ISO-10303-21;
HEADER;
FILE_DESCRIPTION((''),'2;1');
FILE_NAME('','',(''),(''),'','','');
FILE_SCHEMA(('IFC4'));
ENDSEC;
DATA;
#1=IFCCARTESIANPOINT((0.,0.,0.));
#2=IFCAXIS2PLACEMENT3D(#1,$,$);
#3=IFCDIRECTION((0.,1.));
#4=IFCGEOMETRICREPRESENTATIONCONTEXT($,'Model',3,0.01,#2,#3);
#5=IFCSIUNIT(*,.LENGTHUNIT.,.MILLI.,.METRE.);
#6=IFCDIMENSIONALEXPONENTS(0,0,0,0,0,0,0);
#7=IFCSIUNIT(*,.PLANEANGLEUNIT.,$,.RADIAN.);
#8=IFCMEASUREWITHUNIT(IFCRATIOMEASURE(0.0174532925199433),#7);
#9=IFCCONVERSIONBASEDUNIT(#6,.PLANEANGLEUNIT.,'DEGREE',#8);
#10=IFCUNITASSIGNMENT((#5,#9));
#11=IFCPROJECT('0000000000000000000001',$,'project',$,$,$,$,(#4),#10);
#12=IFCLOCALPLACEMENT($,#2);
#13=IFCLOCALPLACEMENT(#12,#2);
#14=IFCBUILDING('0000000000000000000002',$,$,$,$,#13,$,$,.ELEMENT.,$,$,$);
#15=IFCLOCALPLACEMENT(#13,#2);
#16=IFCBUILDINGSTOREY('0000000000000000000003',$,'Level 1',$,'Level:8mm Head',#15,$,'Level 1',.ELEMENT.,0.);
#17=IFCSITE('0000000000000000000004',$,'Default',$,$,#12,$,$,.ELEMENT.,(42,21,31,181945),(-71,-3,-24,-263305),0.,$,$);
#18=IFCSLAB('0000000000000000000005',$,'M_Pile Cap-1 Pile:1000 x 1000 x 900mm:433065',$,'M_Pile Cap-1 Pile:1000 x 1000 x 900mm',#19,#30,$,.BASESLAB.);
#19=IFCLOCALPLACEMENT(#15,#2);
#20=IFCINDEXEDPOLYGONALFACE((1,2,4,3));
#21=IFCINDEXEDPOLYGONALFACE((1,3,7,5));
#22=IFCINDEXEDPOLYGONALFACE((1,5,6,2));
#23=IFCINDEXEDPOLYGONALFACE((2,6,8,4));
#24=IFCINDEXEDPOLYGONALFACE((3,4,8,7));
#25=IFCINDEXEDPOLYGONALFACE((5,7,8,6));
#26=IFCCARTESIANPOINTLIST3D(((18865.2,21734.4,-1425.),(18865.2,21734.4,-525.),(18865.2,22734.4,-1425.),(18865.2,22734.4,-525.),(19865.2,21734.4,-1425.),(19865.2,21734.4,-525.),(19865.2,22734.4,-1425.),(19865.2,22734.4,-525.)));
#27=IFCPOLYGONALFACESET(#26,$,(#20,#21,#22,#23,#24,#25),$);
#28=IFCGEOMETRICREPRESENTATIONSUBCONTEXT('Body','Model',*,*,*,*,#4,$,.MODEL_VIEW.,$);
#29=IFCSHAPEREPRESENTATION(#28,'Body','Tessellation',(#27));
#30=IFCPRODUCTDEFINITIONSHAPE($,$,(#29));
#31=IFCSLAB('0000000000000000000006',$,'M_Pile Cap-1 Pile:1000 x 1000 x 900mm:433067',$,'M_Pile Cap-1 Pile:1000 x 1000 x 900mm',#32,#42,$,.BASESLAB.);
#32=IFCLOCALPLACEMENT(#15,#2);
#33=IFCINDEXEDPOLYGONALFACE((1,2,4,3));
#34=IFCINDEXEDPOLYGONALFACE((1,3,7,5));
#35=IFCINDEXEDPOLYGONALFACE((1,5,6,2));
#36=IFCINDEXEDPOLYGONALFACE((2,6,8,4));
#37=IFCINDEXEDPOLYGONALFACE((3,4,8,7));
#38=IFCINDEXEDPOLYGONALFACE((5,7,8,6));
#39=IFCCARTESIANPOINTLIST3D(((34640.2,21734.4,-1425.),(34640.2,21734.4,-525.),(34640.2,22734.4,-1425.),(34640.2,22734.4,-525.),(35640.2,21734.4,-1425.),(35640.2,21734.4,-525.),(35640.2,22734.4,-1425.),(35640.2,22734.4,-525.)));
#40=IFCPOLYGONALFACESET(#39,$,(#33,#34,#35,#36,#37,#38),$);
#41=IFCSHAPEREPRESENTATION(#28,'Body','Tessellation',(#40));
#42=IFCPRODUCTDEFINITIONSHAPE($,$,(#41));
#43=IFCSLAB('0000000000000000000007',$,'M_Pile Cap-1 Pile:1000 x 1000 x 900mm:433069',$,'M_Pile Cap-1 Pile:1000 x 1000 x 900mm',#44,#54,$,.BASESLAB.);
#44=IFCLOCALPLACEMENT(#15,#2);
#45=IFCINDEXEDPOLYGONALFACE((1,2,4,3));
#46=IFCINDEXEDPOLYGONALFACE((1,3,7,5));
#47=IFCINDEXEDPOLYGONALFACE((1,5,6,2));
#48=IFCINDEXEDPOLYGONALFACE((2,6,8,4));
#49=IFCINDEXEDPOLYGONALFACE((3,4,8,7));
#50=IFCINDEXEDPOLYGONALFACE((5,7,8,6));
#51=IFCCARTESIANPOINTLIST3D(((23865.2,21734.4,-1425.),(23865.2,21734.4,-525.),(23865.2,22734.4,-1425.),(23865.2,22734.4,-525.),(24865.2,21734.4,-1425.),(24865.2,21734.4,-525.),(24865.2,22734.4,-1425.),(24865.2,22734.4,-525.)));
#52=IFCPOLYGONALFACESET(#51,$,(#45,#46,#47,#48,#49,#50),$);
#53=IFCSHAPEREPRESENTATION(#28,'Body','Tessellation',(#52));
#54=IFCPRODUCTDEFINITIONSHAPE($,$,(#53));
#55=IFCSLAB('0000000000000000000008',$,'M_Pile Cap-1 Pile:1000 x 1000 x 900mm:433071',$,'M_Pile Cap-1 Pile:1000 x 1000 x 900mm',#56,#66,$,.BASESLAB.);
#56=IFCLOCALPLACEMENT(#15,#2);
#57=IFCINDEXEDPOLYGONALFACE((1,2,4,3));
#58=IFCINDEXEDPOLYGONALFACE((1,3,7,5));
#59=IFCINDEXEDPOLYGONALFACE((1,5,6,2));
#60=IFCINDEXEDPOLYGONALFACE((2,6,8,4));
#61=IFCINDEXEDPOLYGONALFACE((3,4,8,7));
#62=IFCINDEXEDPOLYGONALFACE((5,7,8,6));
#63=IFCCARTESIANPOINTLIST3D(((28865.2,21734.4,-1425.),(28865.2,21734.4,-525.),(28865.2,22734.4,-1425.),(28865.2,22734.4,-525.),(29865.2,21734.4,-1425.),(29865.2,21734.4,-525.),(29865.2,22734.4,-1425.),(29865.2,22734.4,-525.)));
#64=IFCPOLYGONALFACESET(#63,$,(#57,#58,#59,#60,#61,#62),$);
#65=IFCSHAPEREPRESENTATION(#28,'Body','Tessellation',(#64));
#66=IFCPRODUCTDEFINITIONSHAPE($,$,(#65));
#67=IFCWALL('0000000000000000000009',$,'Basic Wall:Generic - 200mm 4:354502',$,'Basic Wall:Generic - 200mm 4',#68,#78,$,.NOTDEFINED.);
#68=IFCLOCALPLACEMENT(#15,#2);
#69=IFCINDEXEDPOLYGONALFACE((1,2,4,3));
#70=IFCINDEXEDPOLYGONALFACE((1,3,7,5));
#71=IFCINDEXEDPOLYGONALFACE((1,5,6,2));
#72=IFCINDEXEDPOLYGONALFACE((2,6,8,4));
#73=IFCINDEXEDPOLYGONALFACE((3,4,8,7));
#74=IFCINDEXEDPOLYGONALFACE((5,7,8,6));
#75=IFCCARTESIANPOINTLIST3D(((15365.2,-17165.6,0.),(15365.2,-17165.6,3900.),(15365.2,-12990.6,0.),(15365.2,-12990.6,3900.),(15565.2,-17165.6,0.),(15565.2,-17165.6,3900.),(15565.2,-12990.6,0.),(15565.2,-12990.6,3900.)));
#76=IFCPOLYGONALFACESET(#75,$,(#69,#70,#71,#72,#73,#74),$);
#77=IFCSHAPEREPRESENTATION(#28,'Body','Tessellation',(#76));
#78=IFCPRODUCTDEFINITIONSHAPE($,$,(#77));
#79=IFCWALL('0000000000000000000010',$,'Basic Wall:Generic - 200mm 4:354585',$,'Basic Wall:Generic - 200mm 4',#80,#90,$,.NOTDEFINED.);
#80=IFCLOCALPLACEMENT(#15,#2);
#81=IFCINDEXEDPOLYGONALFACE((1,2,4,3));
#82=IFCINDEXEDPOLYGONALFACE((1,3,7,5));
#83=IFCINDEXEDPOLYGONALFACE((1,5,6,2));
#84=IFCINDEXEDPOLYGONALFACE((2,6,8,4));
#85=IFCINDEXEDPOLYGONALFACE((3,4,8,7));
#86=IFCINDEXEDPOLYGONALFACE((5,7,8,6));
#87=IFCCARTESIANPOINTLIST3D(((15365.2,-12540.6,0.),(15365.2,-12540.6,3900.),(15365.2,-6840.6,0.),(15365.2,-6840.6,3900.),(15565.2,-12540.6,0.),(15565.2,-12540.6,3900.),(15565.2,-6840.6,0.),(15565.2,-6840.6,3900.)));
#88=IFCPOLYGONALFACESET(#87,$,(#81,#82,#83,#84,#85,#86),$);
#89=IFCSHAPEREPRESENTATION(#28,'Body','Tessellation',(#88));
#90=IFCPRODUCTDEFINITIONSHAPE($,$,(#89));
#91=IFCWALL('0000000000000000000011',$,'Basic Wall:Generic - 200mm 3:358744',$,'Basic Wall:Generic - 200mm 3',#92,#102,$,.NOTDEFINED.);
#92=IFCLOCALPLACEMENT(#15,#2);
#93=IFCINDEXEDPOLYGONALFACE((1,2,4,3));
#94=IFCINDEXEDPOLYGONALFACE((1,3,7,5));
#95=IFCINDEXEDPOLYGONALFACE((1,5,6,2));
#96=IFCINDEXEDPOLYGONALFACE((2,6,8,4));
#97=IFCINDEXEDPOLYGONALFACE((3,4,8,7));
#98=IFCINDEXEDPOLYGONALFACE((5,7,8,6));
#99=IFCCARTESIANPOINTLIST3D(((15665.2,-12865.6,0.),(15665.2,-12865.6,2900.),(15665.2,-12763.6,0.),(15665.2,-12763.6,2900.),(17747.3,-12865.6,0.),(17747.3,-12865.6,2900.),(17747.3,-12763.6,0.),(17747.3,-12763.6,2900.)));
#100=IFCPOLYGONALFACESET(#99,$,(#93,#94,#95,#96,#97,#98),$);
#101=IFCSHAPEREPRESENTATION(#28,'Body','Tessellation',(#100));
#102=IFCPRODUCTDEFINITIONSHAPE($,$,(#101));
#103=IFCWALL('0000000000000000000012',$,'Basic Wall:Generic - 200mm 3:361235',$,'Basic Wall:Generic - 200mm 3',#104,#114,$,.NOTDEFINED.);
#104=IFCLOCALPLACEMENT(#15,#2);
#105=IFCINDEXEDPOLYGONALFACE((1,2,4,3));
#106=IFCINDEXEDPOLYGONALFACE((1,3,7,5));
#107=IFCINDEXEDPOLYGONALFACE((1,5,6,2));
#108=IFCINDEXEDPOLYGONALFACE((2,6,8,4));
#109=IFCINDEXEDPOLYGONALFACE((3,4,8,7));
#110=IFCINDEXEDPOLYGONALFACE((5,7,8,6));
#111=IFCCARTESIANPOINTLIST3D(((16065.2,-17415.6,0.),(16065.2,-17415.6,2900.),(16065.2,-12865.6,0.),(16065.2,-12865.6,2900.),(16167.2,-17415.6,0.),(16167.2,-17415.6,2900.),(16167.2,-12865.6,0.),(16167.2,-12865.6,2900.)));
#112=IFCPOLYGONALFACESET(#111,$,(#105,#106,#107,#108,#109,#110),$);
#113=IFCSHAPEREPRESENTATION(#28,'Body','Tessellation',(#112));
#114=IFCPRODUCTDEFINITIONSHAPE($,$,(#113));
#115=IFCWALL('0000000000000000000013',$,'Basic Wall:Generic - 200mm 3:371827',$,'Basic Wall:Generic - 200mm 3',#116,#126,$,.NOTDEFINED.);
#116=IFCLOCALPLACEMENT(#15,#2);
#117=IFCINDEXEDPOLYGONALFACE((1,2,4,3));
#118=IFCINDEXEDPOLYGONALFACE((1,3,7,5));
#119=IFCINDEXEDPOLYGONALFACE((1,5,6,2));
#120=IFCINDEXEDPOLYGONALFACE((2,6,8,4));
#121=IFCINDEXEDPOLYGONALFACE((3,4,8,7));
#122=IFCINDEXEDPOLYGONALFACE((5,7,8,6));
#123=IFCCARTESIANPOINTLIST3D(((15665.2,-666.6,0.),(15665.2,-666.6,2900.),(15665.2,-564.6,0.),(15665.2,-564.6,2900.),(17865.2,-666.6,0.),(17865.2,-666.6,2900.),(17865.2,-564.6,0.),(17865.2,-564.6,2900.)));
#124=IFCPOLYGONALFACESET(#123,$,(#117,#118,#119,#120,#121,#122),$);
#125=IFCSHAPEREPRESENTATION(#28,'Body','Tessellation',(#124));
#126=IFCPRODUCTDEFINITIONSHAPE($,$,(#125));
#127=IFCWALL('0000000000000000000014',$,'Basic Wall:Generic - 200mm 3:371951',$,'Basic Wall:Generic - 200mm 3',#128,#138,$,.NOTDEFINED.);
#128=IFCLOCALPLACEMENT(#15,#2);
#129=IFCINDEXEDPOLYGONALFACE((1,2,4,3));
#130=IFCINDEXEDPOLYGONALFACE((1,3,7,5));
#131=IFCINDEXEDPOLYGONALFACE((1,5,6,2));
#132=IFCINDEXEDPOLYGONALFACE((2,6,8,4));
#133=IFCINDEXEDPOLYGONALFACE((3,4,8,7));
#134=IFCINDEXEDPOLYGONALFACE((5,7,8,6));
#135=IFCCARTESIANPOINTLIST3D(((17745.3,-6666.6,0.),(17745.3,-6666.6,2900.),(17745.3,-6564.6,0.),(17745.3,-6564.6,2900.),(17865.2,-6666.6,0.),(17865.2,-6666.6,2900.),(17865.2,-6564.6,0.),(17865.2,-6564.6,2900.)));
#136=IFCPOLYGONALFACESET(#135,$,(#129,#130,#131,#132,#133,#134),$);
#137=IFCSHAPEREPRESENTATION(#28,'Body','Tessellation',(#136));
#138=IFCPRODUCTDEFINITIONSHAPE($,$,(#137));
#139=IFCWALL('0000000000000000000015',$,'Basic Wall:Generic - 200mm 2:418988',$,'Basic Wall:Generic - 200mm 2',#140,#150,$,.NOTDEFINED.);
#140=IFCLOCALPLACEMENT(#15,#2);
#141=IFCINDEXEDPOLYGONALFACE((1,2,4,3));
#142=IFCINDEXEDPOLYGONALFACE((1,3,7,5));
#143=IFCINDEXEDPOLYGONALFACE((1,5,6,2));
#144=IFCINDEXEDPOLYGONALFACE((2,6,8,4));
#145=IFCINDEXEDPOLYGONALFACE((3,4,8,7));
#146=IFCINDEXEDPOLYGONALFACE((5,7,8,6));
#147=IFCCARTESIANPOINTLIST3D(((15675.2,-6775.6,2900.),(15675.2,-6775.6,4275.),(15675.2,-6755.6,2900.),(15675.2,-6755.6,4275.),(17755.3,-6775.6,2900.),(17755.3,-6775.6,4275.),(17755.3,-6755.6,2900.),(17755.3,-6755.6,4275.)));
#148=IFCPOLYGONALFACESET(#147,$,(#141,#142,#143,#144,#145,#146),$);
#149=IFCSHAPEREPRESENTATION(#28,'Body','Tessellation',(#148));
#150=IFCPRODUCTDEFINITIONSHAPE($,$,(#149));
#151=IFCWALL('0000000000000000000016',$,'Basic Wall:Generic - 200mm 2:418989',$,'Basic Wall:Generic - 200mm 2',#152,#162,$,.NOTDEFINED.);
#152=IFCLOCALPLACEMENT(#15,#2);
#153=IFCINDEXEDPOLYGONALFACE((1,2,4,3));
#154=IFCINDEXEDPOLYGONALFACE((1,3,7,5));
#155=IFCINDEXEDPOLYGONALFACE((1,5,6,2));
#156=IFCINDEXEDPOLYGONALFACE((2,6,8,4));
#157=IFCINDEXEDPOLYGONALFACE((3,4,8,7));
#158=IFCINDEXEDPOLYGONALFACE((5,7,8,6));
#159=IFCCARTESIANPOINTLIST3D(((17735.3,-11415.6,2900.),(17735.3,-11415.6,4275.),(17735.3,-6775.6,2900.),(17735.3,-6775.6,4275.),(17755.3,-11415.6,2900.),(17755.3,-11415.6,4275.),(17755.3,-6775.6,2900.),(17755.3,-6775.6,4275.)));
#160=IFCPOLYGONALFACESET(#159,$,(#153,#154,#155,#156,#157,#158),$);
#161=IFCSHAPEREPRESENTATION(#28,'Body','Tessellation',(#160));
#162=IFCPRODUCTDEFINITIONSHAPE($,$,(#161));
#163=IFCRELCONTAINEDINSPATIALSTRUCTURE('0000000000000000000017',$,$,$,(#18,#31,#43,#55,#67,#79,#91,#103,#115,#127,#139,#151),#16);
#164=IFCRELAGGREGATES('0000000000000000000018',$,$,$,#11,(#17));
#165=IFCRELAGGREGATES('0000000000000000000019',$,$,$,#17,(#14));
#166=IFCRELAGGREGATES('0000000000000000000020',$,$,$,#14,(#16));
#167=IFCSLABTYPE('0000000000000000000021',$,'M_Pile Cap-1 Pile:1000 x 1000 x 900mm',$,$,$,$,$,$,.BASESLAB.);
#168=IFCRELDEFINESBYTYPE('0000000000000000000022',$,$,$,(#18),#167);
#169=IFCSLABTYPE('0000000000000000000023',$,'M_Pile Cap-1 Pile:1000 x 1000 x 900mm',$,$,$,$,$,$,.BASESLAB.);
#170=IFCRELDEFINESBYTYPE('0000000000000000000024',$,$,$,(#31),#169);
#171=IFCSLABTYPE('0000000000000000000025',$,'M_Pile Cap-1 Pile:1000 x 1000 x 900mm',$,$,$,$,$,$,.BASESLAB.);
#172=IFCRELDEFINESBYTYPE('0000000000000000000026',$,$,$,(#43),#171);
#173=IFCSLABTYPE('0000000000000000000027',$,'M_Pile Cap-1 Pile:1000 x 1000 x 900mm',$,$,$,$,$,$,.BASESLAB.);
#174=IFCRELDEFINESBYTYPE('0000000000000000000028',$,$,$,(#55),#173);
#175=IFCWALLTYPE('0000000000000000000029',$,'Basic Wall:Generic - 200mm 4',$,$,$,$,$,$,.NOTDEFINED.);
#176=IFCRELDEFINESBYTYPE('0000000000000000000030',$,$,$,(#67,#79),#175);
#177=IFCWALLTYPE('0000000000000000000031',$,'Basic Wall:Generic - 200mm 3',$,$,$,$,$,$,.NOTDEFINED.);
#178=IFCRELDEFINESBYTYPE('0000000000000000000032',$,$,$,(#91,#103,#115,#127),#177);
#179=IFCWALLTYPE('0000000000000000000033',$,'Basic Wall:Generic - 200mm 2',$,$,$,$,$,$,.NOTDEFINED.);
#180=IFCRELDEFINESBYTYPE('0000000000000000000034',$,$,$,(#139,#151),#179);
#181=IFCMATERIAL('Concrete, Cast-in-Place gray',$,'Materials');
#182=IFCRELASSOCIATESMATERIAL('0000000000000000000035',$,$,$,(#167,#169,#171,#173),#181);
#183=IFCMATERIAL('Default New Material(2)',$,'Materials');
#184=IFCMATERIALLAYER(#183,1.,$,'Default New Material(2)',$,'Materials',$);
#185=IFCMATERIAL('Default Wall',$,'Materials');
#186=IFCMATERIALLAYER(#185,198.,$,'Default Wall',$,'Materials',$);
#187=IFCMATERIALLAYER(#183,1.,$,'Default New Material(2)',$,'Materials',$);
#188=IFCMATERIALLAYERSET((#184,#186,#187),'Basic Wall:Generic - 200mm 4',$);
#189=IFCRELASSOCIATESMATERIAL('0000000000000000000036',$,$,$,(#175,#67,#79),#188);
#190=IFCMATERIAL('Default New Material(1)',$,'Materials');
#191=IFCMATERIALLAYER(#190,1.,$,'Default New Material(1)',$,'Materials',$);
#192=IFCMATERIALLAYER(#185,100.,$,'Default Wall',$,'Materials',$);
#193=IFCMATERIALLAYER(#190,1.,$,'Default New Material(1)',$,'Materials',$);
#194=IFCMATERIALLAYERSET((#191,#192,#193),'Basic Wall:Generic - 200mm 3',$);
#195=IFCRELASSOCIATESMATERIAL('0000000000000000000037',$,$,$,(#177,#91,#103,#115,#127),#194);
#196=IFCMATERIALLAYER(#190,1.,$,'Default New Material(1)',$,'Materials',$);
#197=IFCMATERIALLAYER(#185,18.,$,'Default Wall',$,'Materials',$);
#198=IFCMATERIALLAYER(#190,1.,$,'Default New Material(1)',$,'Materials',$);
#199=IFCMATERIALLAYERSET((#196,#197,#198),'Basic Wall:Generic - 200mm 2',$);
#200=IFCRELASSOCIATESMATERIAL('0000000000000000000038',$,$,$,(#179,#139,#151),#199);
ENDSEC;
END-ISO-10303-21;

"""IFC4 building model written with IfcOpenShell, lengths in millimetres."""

from ifc_helpers import new_model, entity, si_unit, converted_unit, direction, frame, origin, place, context, subcontext, project, spatial, indexed_curve, outline, extrude, material, layer, layer_set, type_object, element, save


model = new_model("IFC4")

# Units and contexts
model_context = context("Model", 3, precision=0.01, world=origin(), true_north=direction((0.0, 1.0)))
body_context = subcontext(model_context, "Body", "Model", "MODEL_VIEW")
ifc_project = project(units=[si_unit("LENGTHUNIT", "METRE", prefix="MILLI"), converted_unit("PLANEANGLEUNIT", "DEGREE", entity("IfcRatioMeasure", 0.0174532925199433), si_unit("PLANEANGLEUNIT", "RADIAN"), dimensions=[0, 0, 0, 0, 0, 0, 0])], contexts=[model_context])

# Site, building, storey
site_placement = place(None, origin())
site = spatial("IfcSite", under=ifc_project, at=site_placement, Name="Default", CompositionType="ELEMENT", RefLatitude=(42, 21, 31, 181945), RefLongitude=(-71, -3, -24, -263305), RefElevation=0.0)
building_placement = place(site_placement, origin())
building = spatial("IfcBuilding", under=site, at=building_placement, CompositionType="ELEMENT")
storey_placement = place(building_placement, origin())
storey = spatial("IfcBuildingStorey", under=building, at=storey_placement, Name="Level 1", ObjectType="Level:8mm Head", LongName="Level 1", CompositionType="ELEMENT", Elevation=0.0)

# Slabs
ifc_material_1 = material(Name="Concrete, Cast-in-Place gray", Category="Materials")
slab_type_1 = type_object("IfcSlabType", Name="M_Pile Cap-1 Pile:1000 x 1000 x 900mm", PredefinedType="BASESLAB", material=ifc_material_1)
slab_1_placement = place(building_placement, origin())
element("IfcSlab", 1, at=slab_1_placement, inside=storey, type_object=slab_type_1, Name="M_Pile Cap-1 Pile:1000 x 1000 x 900mm:433065", ObjectType="M_Pile Cap-1 Pile:1000 x 1000 x 900mm", PredefinedType="BASESLAB", context=body_context, shape_type="SweptSolid", body=[
    extrude(outline(indexed_curve([(-500.0, -500.0), (500.0, -500.0), (500.0, 500.0), (-500.0, 500.0), (-500.0, -500.0)], self_intersect=False)), frame((19365.2, 22234.4, -1425.0), z_axis=(0.0, 0.0, 1.0), x_axis=(-1.0, 0.0, 0.0)), (0.0, 0.0, 1.0), 900.0),
])
slab_type_2 = type_object("IfcSlabType", Name="M_Pile Cap-1 Pile:1000 x 1000 x 900mm", PredefinedType="BASESLAB", material=ifc_material_1)
slab_2_placement = place(building_placement, origin())
element("IfcSlab", 2, at=slab_2_placement, inside=storey, type_object=slab_type_2, Name="M_Pile Cap-1 Pile:1000 x 1000 x 900mm:433067", ObjectType="M_Pile Cap-1 Pile:1000 x 1000 x 900mm", PredefinedType="BASESLAB", context=body_context, shape_type="SweptSolid", body=[
    extrude(outline(indexed_curve([(-500.0, -500.0), (500.0, -500.0), (500.0, 500.0), (-500.0, 500.0), (-500.0, -500.0)], self_intersect=False)), frame((35140.2, 22234.4, -1425.0), z_axis=(0.0, 0.0, 1.0), x_axis=(-1.0, 0.0, 0.0)), (0.0, 0.0, 1.0), 900.0),
])
slab_type_3 = type_object("IfcSlabType", Name="M_Pile Cap-1 Pile:1000 x 1000 x 900mm", PredefinedType="BASESLAB", material=ifc_material_1)
slab_3_placement = place(building_placement, origin())
element("IfcSlab", 3, at=slab_3_placement, inside=storey, type_object=slab_type_3, Name="M_Pile Cap-1 Pile:1000 x 1000 x 900mm:433069", ObjectType="M_Pile Cap-1 Pile:1000 x 1000 x 900mm", PredefinedType="BASESLAB", context=body_context, shape_type="SweptSolid", body=[
    extrude(outline(indexed_curve([(-500.0, -500.0), (500.0, -500.0), (500.0, 500.0), (-500.0, 500.0), (-500.0, -500.0)], self_intersect=False)), frame((24365.2, 22234.4, -1425.0), z_axis=(0.0, 0.0, 1.0), x_axis=(-1.0, 0.0, 0.0)), (0.0, 0.0, 1.0), 900.0),
])
slab_type_4 = type_object("IfcSlabType", Name="M_Pile Cap-1 Pile:1000 x 1000 x 900mm", PredefinedType="BASESLAB", material=ifc_material_1)
slab_4_placement = place(building_placement, origin())
element("IfcSlab", 4, at=slab_4_placement, inside=storey, type_object=slab_type_4, Name="M_Pile Cap-1 Pile:1000 x 1000 x 900mm:433071", ObjectType="M_Pile Cap-1 Pile:1000 x 1000 x 900mm", PredefinedType="BASESLAB", context=body_context, shape_type="SweptSolid", body=[
    extrude(outline(indexed_curve([(-500.0, -500.0), (500.0, -500.0), (500.0, 500.0), (-500.0, 500.0), (-500.0, -500.0)], self_intersect=False)), frame((29365.2, 22234.4, -1425.0), z_axis=(0.0, 0.0, 1.0), x_axis=(-1.0, 0.0, 0.0)), (0.0, 0.0, 1.0), 900.0),
])

# Walls
ifc_material_2 = material(Name="Default New Material(2)", Category="Materials")
ifc_layer_1 = layer(ifc_material_2, 1.0, Name="Default New Material(2)", Category="Materials")
ifc_material_3 = material(Name="Default Wall", Category="Materials")
ifc_layer_2 = layer(ifc_material_3, 198.0, Name="Default Wall", Category="Materials")
ifc_layer_3 = layer(ifc_material_2, 1.0, Name="Default New Material(2)", Category="Materials")
ifc_layer_set_1 = layer_set([ifc_layer_1, ifc_layer_2, ifc_layer_3], Name="Basic Wall:Generic - 200mm 4")
wall_type_1 = type_object("IfcWallType", Name="Basic Wall:Generic - 200mm 4", PredefinedType="NOTDEFINED", material=ifc_layer_set_1)
wall_1_placement = place(storey_placement, frame((15465.2, -17165.6, 0.0), z_axis=(0.0, 0.0, 1.0), x_axis=(0.0, 1.0, 0.0)))
element("IfcWall", 5, at=wall_1_placement, inside=storey, type_object=wall_type_1, material=ifc_layer_set_1, Name="Basic Wall:Generic - 200mm 4:354502", ObjectType="Basic Wall:Generic - 200mm 4", PredefinedType="NOTDEFINED", context=body_context, shape_type="SweptSolid", body=[
    extrude(outline(indexed_curve([(4175.0, 100.0), (0.0, 100.0), (0.0, -100.0), (4175.0, -100.0), (4175.0, 100.0)], self_intersect=False)), origin(), (0.0, 0.0, 1.0), 3900.0),
])
wall_2_placement = place(storey_placement, frame((15465.2, -12540.6, 0.0), z_axis=(0.0, 0.0, 1.0), x_axis=(0.0, 1.0, 0.0)))
element("IfcWall", 6, at=wall_2_placement, inside=storey, type_object=wall_type_1, material=ifc_layer_set_1, Name="Basic Wall:Generic - 200mm 4:354585", ObjectType="Basic Wall:Generic - 200mm 4", PredefinedType="NOTDEFINED", context=body_context, shape_type="SweptSolid", body=[
    extrude(outline(indexed_curve([(5700.0, 100.0), (0.0, 100.0), (0.0, -100.0), (5700.0, -100.0), (5700.0, 100.0)], self_intersect=False)), origin(), (0.0, 0.0, 1.0), 3900.0),
])
ifc_material_4 = material(Name="Default New Material(1)", Category="Materials")
ifc_layer_4 = layer(ifc_material_4, 1.0, Name="Default New Material(1)", Category="Materials")
ifc_layer_5 = layer(ifc_material_3, 100.0, Name="Default Wall", Category="Materials")
ifc_layer_6 = layer(ifc_material_4, 1.0, Name="Default New Material(1)", Category="Materials")
ifc_layer_set_2 = layer_set([ifc_layer_4, ifc_layer_5, ifc_layer_6], Name="Basic Wall:Generic - 200mm 3")
wall_type_2 = type_object("IfcWallType", Name="Basic Wall:Generic - 200mm 3", PredefinedType="NOTDEFINED", material=ifc_layer_set_2)
wall_3_placement = place(storey_placement, frame((15665.2, -12814.6, 0.0)))
element("IfcWall", 7, at=wall_3_placement, inside=storey, type_object=wall_type_2, material=ifc_layer_set_2, Name="Basic Wall:Generic - 200mm 3:358744", ObjectType="Basic Wall:Generic - 200mm 3", PredefinedType="NOTDEFINED", context=body_context, shape_type="SweptSolid", body=[
    extrude(outline(indexed_curve([(2082.1, 51.0), (0.0, 51.0), (0.0, -51.0), (2082.1, -51.0), (2082.1, 51.0)], self_intersect=False)), origin(), (0.0, 0.0, 1.0), 2900.0),
])
wall_4_placement = place(storey_placement, frame((16116.2, -12865.6, 0.0), z_axis=(0.0, 0.0, 1.0), x_axis=(0.0, -1.0, 0.0)))
element("IfcWall", 8, at=wall_4_placement, inside=storey, type_object=wall_type_2, material=ifc_layer_set_2, Name="Basic Wall:Generic - 200mm 3:361235", ObjectType="Basic Wall:Generic - 200mm 3", PredefinedType="NOTDEFINED", context=body_context, shape_type="SweptSolid", body=[
    extrude(outline(indexed_curve([(4550.0, 51.0), (0.0, 51.0), (0.0, -51.0), (4550.0, -51.0), (4550.0, 51.0)], self_intersect=False)), origin(), (0.0, 0.0, 1.0), 2900.0),
])
wall_5_placement = place(storey_placement, frame((15665.2, -615.6, 0.0)))
element("IfcWall", 9, at=wall_5_placement, inside=storey, type_object=wall_type_2, material=ifc_layer_set_2, Name="Basic Wall:Generic - 200mm 3:371827", ObjectType="Basic Wall:Generic - 200mm 3", PredefinedType="NOTDEFINED", context=body_context, shape_type="SweptSolid", body=[
    extrude(outline(indexed_curve([(2200.0, 51.0), (0.0, 51.0), (0.0, -51.0), (2200.0, -51.0), (2200.0, 51.0)], self_intersect=False)), origin(), (0.0, 0.0, 1.0), 2900.0),
])
wall_6_placement = place(storey_placement, frame((17745.3, -6615.6, 0.0)))
element("IfcWall", 10, at=wall_6_placement, inside=storey, type_object=wall_type_2, material=ifc_layer_set_2, Name="Basic Wall:Generic - 200mm 3:371951", ObjectType="Basic Wall:Generic - 200mm 3", PredefinedType="NOTDEFINED", context=body_context, shape_type="SweptSolid", body=[
    extrude(outline(indexed_curve([(119.9, 51.0), (0.0, 51.0), (0.0, -51.0), (119.9, -51.0), (119.9, 51.0)], self_intersect=False)), origin(), (0.0, 0.0, 1.0), 2900.0),
])
ifc_layer_7 = layer(ifc_material_4, 1.0, Name="Default New Material(1)", Category="Materials")
ifc_layer_8 = layer(ifc_material_3, 18.0, Name="Default Wall", Category="Materials")
ifc_layer_9 = layer(ifc_material_4, 1.0, Name="Default New Material(1)", Category="Materials")
ifc_layer_set_3 = layer_set([ifc_layer_7, ifc_layer_8, ifc_layer_9], Name="Basic Wall:Generic - 200mm 2")
wall_type_3 = type_object("IfcWallType", Name="Basic Wall:Generic - 200mm 2", PredefinedType="NOTDEFINED", material=ifc_layer_set_3)
wall_7_placement = place(storey_placement, frame((17755.3, -6765.6, 2900.0), z_axis=(0.0, 0.0, 1.0), x_axis=(-1.0, 0.0, 0.0)))
element("IfcWall", 11, at=wall_7_placement, inside=storey, type_object=wall_type_3, material=ifc_layer_set_3, Name="Basic Wall:Generic - 200mm 2:418988", ObjectType="Basic Wall:Generic - 200mm 2", PredefinedType="NOTDEFINED", context=body_context, shape_type="SweptSolid", body=[
    extrude(outline(indexed_curve([(2080.1, 10.0), (0.0, 10.0), (0.0, -10.0), (2080.1, -10.0), (2080.1, 10.0)], self_intersect=False)), origin(), (0.0, 0.0, 1.0), 1375.0),
])
wall_8_placement = place(storey_placement, frame((17745.3, -11415.6, 2900.0), z_axis=(0.0, 0.0, 1.0), x_axis=(0.0, 1.0, 0.0)))
element("IfcWall", 12, at=wall_8_placement, inside=storey, type_object=wall_type_3, material=ifc_layer_set_3, Name="Basic Wall:Generic - 200mm 2:418989", ObjectType="Basic Wall:Generic - 200mm 2", PredefinedType="NOTDEFINED", context=body_context, shape_type="SweptSolid", body=[
    extrude(outline(indexed_curve([(4640.0, 10.0), (0.0, 10.0), (0.0, -10.0), (4640.0, -10.0), (4640.0, 10.0)], self_intersect=False)), origin(), (0.0, 0.0, 1.0), 1375.0),
])

save(model, "model.ifc")
